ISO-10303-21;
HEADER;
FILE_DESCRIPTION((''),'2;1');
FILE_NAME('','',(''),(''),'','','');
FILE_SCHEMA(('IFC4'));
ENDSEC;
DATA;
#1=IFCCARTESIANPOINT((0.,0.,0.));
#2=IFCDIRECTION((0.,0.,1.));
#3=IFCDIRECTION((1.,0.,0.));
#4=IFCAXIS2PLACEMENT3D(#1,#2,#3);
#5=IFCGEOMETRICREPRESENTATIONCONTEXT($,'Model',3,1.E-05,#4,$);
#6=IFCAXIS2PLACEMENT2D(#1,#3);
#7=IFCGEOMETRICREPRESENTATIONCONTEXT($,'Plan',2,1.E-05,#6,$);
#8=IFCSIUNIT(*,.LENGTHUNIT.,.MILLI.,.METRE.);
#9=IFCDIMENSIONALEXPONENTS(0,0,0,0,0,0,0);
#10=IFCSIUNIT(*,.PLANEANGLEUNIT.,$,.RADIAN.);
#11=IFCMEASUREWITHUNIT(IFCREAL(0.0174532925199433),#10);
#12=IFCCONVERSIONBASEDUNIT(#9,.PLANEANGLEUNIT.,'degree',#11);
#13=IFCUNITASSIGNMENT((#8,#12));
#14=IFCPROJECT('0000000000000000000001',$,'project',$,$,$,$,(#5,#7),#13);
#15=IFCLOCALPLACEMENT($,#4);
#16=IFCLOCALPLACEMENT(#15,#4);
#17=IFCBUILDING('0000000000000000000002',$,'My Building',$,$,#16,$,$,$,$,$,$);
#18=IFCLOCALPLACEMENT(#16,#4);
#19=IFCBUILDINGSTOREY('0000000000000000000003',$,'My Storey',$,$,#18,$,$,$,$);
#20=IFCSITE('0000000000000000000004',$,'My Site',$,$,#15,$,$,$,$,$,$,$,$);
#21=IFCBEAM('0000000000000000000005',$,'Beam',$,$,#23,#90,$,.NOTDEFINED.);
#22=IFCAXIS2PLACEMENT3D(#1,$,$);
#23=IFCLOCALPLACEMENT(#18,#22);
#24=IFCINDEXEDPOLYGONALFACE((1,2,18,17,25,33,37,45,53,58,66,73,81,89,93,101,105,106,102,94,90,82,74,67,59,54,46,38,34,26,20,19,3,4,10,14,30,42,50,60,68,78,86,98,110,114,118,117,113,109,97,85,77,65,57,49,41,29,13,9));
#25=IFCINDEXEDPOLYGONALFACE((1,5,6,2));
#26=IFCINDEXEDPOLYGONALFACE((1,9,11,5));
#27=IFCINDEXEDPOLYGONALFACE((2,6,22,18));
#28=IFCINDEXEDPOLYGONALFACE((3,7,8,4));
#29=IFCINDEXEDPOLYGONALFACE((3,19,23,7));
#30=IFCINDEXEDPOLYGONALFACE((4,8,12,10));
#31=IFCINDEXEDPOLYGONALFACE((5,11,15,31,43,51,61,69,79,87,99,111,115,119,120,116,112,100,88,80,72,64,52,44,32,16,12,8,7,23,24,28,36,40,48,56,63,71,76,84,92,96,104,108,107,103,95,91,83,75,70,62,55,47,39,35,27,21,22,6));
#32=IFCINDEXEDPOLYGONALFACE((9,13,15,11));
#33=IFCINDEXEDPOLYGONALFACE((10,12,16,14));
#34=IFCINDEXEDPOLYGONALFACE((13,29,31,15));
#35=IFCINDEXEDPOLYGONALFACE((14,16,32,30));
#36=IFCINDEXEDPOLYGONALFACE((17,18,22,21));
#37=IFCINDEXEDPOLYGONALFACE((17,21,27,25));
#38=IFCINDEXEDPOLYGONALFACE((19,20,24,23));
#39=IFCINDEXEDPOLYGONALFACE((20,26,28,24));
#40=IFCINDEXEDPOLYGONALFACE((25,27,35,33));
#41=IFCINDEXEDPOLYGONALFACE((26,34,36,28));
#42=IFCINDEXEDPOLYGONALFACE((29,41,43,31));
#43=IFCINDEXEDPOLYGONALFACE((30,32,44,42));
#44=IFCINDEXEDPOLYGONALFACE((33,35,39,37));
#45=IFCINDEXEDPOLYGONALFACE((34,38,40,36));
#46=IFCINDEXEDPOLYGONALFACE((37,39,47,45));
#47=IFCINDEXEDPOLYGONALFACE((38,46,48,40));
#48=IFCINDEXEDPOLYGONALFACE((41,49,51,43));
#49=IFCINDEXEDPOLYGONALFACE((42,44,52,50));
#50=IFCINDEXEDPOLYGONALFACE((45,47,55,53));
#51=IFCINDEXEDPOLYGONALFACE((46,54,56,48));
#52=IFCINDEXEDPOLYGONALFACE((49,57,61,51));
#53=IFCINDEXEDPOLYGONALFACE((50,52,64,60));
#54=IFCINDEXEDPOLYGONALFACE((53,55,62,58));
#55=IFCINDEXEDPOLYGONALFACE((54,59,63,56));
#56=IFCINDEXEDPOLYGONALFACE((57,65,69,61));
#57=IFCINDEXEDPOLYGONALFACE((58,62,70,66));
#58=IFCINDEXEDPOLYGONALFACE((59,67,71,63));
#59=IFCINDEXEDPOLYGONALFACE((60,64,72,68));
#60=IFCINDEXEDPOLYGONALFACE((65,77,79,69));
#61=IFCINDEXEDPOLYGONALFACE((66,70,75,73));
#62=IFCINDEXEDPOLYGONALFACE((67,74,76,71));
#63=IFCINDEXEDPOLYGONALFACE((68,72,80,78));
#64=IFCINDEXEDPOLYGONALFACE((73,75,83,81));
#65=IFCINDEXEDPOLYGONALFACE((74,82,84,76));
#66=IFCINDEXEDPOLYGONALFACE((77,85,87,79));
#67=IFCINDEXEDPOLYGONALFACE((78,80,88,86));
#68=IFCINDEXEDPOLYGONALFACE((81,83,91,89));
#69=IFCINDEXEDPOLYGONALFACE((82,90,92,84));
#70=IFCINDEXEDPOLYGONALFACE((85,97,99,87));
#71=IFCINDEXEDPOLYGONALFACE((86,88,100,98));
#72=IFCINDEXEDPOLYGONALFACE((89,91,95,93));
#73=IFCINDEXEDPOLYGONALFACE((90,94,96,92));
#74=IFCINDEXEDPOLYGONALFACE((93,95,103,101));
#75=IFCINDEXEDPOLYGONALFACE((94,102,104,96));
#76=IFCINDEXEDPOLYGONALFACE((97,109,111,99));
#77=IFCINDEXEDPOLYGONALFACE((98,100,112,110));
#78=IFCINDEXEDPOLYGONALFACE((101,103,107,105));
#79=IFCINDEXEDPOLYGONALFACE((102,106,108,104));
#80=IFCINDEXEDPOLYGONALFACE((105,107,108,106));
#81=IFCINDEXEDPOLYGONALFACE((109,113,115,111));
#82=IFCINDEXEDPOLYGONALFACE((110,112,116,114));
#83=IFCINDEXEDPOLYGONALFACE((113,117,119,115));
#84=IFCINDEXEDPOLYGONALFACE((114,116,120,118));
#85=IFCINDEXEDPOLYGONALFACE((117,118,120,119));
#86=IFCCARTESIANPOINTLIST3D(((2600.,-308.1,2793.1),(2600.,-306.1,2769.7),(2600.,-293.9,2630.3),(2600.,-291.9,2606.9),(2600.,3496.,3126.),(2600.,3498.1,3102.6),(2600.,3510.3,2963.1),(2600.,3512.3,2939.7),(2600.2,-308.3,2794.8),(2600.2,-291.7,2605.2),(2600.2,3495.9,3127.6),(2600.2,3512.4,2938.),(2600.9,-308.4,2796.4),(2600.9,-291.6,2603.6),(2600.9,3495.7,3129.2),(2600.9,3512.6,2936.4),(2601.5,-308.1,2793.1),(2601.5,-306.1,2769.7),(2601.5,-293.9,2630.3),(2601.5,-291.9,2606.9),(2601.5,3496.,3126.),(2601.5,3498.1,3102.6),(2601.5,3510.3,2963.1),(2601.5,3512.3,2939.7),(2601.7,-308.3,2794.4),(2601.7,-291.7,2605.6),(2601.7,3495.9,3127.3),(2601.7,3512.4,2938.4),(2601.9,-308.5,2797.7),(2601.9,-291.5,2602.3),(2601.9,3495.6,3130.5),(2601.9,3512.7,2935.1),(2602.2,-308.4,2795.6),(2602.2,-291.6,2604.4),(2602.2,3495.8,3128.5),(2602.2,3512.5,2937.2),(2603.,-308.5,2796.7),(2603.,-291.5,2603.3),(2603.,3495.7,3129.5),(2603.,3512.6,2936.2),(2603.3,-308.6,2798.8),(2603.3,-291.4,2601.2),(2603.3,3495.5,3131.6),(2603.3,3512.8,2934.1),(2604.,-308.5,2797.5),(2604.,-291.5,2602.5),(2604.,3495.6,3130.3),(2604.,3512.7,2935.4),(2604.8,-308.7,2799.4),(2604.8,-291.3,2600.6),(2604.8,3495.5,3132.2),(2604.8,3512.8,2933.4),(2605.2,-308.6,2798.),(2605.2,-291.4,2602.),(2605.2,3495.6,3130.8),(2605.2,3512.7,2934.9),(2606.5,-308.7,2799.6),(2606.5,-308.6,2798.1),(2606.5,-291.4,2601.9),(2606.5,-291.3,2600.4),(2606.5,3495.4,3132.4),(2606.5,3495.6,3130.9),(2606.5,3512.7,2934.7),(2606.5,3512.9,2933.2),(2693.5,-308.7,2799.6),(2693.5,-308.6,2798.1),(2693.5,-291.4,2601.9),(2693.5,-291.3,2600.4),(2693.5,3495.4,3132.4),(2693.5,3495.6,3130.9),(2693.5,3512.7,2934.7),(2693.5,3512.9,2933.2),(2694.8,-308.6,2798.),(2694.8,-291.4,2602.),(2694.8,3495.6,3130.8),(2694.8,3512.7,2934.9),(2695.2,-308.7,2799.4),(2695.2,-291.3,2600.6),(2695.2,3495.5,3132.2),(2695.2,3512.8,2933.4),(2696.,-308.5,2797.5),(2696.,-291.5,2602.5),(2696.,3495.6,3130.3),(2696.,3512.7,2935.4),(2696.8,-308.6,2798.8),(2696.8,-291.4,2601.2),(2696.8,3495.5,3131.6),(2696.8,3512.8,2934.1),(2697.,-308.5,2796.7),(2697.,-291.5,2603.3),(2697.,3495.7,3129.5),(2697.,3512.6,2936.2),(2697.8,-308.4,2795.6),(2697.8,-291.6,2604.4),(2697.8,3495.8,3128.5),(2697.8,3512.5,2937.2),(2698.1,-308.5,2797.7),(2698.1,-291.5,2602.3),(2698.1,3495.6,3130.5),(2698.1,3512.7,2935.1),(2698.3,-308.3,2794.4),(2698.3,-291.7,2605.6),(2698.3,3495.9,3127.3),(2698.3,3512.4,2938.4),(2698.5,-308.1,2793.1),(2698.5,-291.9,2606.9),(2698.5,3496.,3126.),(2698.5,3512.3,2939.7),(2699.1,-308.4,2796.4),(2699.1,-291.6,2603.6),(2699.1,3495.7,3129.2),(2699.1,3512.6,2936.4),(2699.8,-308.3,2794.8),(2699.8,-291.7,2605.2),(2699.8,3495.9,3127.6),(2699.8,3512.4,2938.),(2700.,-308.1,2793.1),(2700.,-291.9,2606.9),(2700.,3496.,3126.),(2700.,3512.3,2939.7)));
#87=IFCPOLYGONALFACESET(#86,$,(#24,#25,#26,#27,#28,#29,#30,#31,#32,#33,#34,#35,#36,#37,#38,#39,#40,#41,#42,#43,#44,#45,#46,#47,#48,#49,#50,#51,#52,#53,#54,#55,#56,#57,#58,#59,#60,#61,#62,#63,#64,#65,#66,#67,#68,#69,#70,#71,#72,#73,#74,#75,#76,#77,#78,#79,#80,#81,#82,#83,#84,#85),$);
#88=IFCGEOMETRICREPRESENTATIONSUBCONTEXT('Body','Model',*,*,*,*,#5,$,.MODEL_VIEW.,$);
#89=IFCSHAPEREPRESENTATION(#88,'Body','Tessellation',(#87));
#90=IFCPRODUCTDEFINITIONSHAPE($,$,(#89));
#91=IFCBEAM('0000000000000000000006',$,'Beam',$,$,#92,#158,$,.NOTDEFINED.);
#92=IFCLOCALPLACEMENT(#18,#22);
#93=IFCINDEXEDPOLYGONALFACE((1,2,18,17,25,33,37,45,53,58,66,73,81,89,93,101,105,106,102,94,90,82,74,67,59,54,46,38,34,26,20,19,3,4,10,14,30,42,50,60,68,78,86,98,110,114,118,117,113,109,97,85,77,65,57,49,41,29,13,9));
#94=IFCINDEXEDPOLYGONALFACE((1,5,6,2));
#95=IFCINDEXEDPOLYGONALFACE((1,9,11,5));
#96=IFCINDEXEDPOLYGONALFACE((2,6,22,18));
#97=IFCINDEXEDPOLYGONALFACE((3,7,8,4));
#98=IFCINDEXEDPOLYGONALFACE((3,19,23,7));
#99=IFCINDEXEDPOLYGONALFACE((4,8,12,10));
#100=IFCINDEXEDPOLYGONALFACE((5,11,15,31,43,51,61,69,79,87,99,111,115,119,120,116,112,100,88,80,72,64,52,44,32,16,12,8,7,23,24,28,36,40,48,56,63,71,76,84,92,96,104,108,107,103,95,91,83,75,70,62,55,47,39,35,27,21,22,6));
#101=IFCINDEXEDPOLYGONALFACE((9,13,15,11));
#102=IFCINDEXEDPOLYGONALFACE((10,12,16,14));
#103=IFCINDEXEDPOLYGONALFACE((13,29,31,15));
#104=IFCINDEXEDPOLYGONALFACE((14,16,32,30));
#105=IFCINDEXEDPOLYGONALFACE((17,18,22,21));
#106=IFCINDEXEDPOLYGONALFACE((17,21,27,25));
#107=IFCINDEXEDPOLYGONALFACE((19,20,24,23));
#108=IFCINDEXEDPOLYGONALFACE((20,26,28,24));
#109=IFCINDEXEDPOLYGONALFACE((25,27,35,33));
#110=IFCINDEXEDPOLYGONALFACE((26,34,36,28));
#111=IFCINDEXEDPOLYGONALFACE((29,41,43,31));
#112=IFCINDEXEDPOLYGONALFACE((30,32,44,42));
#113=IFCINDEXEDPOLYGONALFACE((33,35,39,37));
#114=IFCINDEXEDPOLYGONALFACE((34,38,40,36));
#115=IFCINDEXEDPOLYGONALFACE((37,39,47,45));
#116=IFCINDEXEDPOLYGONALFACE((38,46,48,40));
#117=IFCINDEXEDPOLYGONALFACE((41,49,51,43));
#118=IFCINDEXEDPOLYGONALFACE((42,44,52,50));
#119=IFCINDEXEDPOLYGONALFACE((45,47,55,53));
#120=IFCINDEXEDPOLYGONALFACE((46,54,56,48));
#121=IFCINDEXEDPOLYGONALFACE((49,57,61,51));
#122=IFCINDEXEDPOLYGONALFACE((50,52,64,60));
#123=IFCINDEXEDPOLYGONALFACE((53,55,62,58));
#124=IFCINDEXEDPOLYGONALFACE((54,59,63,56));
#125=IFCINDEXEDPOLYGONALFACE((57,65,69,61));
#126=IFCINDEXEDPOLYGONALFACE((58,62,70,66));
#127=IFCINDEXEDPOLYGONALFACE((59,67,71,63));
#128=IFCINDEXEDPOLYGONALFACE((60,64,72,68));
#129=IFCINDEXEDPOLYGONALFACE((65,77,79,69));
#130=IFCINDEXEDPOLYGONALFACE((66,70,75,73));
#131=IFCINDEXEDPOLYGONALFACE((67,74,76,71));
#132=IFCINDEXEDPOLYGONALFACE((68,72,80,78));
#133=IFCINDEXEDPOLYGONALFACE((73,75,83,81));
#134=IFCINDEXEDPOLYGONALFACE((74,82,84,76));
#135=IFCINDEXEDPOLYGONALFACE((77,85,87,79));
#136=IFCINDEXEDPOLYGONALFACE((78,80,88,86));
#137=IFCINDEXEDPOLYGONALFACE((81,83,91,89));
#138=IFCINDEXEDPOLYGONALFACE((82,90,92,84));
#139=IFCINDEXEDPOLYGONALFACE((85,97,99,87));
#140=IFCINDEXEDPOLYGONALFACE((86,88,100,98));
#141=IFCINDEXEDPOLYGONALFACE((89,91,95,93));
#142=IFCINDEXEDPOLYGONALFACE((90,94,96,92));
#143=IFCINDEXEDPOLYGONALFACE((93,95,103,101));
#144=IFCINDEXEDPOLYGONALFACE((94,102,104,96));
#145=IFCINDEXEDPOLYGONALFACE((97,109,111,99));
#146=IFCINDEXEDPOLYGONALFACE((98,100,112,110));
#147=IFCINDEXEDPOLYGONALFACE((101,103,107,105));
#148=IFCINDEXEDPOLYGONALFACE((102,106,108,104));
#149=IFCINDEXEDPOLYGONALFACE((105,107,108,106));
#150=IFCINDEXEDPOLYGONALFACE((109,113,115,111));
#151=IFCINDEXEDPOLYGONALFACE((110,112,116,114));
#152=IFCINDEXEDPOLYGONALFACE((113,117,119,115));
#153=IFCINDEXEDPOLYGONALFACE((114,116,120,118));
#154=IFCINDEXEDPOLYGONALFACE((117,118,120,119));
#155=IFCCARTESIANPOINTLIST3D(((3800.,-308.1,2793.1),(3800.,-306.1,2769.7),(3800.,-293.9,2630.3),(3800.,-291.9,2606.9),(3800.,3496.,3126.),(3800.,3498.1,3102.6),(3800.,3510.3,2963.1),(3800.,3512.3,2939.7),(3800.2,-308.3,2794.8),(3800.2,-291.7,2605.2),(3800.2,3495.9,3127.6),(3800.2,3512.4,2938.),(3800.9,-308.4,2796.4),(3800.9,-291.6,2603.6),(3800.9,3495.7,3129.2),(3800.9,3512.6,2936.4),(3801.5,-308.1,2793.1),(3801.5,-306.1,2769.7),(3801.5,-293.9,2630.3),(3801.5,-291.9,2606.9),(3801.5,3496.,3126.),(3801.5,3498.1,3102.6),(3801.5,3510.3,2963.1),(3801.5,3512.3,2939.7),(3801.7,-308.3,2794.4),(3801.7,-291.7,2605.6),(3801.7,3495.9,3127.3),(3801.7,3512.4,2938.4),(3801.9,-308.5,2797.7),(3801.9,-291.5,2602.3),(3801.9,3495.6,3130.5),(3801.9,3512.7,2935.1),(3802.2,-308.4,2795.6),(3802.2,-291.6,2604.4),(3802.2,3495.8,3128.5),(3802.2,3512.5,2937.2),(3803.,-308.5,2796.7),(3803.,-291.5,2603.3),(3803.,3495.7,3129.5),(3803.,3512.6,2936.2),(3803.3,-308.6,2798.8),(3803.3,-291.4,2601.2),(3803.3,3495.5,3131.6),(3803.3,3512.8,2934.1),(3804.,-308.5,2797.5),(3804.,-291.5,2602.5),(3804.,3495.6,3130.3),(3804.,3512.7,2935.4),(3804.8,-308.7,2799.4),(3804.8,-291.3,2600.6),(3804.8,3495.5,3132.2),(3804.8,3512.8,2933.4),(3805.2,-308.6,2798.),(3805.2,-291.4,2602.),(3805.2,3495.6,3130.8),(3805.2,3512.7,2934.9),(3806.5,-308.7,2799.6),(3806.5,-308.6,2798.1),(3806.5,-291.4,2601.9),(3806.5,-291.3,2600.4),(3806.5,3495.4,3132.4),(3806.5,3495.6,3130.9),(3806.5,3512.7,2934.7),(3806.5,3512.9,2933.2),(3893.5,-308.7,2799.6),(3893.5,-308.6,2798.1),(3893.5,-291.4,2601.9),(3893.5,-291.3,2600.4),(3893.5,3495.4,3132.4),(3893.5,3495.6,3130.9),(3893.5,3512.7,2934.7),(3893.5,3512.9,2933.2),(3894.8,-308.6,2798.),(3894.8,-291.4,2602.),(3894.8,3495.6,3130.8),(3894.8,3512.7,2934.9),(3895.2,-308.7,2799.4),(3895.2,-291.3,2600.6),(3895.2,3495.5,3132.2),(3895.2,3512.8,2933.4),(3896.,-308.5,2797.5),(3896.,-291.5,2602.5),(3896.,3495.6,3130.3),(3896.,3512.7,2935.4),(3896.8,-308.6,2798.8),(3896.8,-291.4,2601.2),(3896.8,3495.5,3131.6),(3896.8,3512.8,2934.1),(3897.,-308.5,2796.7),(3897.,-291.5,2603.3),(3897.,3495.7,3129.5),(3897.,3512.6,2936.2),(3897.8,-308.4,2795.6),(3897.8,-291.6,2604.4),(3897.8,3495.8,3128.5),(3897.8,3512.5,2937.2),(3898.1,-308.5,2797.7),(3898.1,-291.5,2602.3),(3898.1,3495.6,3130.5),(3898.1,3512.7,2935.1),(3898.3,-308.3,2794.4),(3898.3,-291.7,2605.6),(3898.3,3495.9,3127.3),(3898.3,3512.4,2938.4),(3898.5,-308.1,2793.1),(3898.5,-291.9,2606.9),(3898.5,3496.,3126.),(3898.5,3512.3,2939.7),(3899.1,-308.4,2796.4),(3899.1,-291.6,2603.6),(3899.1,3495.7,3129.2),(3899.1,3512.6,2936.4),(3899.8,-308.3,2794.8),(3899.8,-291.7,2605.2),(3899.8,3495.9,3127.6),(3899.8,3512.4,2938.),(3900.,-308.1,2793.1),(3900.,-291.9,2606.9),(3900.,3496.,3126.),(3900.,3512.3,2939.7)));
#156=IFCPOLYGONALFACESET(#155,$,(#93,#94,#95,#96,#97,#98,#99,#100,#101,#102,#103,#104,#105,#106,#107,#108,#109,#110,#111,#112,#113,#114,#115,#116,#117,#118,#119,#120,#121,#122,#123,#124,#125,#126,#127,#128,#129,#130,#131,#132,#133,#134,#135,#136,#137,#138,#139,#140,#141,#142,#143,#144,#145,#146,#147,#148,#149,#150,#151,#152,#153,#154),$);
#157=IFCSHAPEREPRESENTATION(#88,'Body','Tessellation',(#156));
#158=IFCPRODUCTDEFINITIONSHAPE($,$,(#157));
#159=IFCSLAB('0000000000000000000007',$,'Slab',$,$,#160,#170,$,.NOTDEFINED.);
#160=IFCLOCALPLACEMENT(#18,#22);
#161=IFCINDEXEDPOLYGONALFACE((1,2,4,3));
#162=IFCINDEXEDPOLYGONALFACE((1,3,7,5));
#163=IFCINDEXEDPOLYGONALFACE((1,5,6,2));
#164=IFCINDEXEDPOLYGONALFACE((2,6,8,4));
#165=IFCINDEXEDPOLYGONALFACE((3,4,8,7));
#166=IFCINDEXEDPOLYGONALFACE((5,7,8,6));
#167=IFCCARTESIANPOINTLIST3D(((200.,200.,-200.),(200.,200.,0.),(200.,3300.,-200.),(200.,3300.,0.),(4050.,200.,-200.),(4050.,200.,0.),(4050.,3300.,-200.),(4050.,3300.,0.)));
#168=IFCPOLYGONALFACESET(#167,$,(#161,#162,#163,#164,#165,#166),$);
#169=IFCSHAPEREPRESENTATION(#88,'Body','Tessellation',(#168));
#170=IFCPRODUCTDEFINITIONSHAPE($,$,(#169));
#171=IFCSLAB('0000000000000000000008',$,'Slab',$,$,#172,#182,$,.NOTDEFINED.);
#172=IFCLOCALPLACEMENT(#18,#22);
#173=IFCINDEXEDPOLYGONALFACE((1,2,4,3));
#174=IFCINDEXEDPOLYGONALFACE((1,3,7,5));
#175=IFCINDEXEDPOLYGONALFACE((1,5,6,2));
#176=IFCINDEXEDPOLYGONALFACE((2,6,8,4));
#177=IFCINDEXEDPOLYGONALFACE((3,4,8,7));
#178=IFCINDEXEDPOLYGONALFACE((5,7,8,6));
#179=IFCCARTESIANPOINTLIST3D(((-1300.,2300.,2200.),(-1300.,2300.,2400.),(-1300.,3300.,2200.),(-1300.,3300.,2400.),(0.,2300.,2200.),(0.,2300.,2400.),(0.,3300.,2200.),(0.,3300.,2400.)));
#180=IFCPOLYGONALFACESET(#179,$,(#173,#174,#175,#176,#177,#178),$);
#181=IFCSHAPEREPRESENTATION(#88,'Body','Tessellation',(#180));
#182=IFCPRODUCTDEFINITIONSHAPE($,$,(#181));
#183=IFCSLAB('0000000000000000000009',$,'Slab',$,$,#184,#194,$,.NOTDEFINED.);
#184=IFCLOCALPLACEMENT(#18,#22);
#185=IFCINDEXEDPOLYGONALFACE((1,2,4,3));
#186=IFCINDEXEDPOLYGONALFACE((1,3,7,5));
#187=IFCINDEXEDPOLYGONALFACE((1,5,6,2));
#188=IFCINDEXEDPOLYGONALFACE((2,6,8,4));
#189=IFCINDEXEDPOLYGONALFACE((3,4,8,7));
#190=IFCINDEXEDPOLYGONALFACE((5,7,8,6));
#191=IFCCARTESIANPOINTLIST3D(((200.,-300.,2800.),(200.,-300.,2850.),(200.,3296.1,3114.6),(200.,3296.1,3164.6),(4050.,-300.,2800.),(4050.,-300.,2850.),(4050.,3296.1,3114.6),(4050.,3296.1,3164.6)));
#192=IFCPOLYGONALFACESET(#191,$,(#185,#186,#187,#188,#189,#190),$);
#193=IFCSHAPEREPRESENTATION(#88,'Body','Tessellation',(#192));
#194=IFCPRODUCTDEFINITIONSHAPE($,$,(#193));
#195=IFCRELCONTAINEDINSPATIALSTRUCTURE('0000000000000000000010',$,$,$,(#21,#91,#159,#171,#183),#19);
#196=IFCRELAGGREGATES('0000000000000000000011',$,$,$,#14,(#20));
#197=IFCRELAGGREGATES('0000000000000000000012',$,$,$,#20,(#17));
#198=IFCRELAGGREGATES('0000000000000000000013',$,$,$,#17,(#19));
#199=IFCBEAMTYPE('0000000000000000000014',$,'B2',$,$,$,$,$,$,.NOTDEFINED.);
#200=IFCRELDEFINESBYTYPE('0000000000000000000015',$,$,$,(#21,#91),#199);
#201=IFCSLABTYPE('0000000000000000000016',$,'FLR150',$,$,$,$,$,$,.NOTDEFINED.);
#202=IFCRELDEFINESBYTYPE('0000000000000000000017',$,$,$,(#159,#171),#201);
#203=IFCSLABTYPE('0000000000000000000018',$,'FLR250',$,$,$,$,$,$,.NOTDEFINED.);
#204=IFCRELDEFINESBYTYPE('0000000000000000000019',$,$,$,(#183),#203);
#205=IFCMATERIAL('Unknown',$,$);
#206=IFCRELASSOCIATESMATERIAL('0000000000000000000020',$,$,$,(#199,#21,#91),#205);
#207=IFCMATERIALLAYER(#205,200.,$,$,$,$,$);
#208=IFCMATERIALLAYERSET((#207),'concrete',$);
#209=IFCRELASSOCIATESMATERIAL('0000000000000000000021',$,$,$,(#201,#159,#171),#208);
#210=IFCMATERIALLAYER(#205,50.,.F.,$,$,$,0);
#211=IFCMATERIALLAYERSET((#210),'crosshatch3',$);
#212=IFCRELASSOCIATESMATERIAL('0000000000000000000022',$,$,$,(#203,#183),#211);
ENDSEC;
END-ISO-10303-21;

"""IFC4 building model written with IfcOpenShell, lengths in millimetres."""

from ifc_helpers import new_model, entity, si_unit, converted_unit, frame, frame_2d, origin_with_axes, place, context, subcontext, project, spatial, line, indexed_curve, c_section, outline, extrude, material, layer, layer_set, layer_usage, material_profile, profile_set, profile_usage, type_object, element, save


model = new_model("IFC4")

# Units and contexts
model_context = context("Model", 3, precision=1e-05, world=origin_with_axes())
plan_context = context("Plan", 2, precision=1e-05, world=frame_2d((0.0, 0.0, 0.0), x_axis=(1.0, 0.0, 0.0)))
body_context = subcontext(model_context, "Body", "Model", "MODEL_VIEW")
ifc_project = project(units=[si_unit("LENGTHUNIT", "METRE", prefix="MILLI"), converted_unit("PLANEANGLEUNIT", "degree", entity("IfcReal", 0.0174532925199433), si_unit("PLANEANGLEUNIT", "RADIAN"), dimensions=[0, 0, 0, 0, 0, 0, 0])], contexts=[model_context, plan_context])

# Site, building, storey
site_placement = place(None, origin_with_axes())
site = spatial("IfcSite", under=ifc_project, at=site_placement, Name="My Site")
building_placement = place(site_placement, origin_with_axes())
building = spatial("IfcBuilding", under=site, at=building_placement, Name="My Building")
storey_placement = place(building_placement, origin_with_axes())
storey = spatial("IfcBuildingStorey", under=building, at=storey_placement, Name="My Storey")

# Shared definitions
ifc_material = material(Name="Unknown")

# Beams
ifc_material_profile_1 = material_profile(ifc_material, c_section(Depth=200.0, Width=100.0, WallThickness=1.5, Girth=30.0, InternalFilletRadius=5.0))
ifc_profile_set_1 = profile_set([ifc_material_profile_1])
beam_type_1 = type_object("IfcBeamType", Name="B2", PredefinedType="NOTDEFINED", material=ifc_profile_set_1)
ifc_profile_usage_1 = profile_usage(ifc_profile_set_1, cardinal=5)
beam_1_placement = place(storey_placement, frame((2650.0, -300.0, 2700.0), z_axis=(0.0, 0.996195, 0.087156), x_axis=(-1.0, 0.0, 0.0)))
element("IfcBeam", 1, at=beam_1_placement, inside=storey, type_object=beam_type_1, material=ifc_profile_usage_1, Name="Beam", PredefinedType="NOTDEFINED", context=body_context, shape_type="SweptSolid", body=[
    extrude(c_section(Depth=200.0, Width=100.0, WallThickness=1.5, Girth=30.0, InternalFilletRadius=5.0), origin_with_axes(), (0.0, 0.0, 1.0), 3818.7),
])
ifc_profile_usage_2 = profile_usage(ifc_profile_set_1, cardinal=5)
beam_2_placement = place(storey_placement, frame((3850.0, -300.0, 2700.0), z_axis=(0.0, 0.996195, 0.087156), x_axis=(-1.0, 0.0, 0.0)))
element("IfcBeam", 2, at=beam_2_placement, inside=storey, type_object=beam_type_1, material=ifc_profile_usage_2, Name="Beam", PredefinedType="NOTDEFINED", context=body_context, shape_type="SweptSolid", body=[
    extrude(c_section(Depth=200.0, Width=100.0, WallThickness=1.5, Girth=30.0, InternalFilletRadius=5.0), origin_with_axes(), (0.0, 0.0, 1.0), 3818.7),
])

# Slabs
ifc_layer_1 = layer(ifc_material, 200.0)
ifc_layer_set_1 = layer_set([ifc_layer_1], Name="concrete")
ifc_layer_usage_1 = layer_usage(ifc_layer_set_1, "AXIS3", "POSITIVE", 0.0)
slab_type_1 = type_object("IfcSlabType", Name="FLR150", PredefinedType="NOTDEFINED", material=ifc_layer_set_1)
slab_1_placement = place(storey_placement, frame((200.0, 200.0, -200.0), z_axis=(0.0, 0.0, 1.0), x_axis=(1.0, 0.0, 0.0)))
element("IfcSlab", 3, at=slab_1_placement, inside=storey, type_object=slab_type_1, material=ifc_layer_usage_1, Name="Slab", PredefinedType="NOTDEFINED", context=body_context, shape_type="SweptSolid", body=[
    extrude(outline(indexed_curve([(0.0, 0.0), (3850.0, 0.0), (3850.0, 3100.0), (0.0, 3100.0)], segments=[line(3, 2), line(2, 1), line(1, 4), line(4, 3)], self_intersect=False)), None, (0.0, 0.0, 1.0), 200.0),
])
ifc_layer_usage_2 = layer_usage(ifc_layer_set_1, "AXIS3", "POSITIVE", 0.0)
slab_2_placement = place(storey_placement, frame((-1300.0, 2300.0, 2200.0), z_axis=(0.0, 0.0, 1.0), x_axis=(1.0, 0.0, 0.0)))
element("IfcSlab", 4, at=slab_2_placement, inside=storey, type_object=slab_type_1, material=ifc_layer_usage_2, Name="Slab", PredefinedType="NOTDEFINED", context=body_context, shape_type="SweptSolid", body=[
    extrude(outline(indexed_curve([(0.0, 0.0), (1300.0, 0.0), (1300.0, 1000.0), (0.0, 1000.0)], segments=[line(3, 2), line(2, 1), line(1, 4), line(4, 3)], self_intersect=False)), None, (0.0, 0.0, 1.0), 200.0),
])
ifc_layer_2 = layer(ifc_material, 50.0, ventilated=False, Priority=0)
ifc_layer_set_2 = layer_set([ifc_layer_2], Name="crosshatch3")
ifc_layer_usage_3 = layer_usage(ifc_layer_set_2, "AXIS3", "POSITIVE", 0.0)
slab_type_2 = type_object("IfcSlabType", Name="FLR250", PredefinedType="NOTDEFINED", material=ifc_layer_set_2)
slab_3_placement = place(storey_placement, frame((200.0, -300.0, 2800.0), z_axis=(0.0, -0.087156, 0.996195), x_axis=(1.0, 0.0, 0.0)))
element("IfcSlab", 5, at=slab_3_placement, inside=storey, type_object=slab_type_2, material=ifc_layer_usage_3, Name="Slab", PredefinedType="NOTDEFINED", context=body_context, shape_type="SweptSolid", body=[
    extrude(outline(indexed_curve([(3850.0, 3609.8), (3850.0, 0.0), (0.0, 0.0), (0.0, 3609.8)], segments=[line(3, 2), line(2, 1), line(1, 4), line(4, 3)], self_intersect=False)), None, (0.0, 0.087156, 0.996195), 50.0),
])

save(model, "model.ifc")
